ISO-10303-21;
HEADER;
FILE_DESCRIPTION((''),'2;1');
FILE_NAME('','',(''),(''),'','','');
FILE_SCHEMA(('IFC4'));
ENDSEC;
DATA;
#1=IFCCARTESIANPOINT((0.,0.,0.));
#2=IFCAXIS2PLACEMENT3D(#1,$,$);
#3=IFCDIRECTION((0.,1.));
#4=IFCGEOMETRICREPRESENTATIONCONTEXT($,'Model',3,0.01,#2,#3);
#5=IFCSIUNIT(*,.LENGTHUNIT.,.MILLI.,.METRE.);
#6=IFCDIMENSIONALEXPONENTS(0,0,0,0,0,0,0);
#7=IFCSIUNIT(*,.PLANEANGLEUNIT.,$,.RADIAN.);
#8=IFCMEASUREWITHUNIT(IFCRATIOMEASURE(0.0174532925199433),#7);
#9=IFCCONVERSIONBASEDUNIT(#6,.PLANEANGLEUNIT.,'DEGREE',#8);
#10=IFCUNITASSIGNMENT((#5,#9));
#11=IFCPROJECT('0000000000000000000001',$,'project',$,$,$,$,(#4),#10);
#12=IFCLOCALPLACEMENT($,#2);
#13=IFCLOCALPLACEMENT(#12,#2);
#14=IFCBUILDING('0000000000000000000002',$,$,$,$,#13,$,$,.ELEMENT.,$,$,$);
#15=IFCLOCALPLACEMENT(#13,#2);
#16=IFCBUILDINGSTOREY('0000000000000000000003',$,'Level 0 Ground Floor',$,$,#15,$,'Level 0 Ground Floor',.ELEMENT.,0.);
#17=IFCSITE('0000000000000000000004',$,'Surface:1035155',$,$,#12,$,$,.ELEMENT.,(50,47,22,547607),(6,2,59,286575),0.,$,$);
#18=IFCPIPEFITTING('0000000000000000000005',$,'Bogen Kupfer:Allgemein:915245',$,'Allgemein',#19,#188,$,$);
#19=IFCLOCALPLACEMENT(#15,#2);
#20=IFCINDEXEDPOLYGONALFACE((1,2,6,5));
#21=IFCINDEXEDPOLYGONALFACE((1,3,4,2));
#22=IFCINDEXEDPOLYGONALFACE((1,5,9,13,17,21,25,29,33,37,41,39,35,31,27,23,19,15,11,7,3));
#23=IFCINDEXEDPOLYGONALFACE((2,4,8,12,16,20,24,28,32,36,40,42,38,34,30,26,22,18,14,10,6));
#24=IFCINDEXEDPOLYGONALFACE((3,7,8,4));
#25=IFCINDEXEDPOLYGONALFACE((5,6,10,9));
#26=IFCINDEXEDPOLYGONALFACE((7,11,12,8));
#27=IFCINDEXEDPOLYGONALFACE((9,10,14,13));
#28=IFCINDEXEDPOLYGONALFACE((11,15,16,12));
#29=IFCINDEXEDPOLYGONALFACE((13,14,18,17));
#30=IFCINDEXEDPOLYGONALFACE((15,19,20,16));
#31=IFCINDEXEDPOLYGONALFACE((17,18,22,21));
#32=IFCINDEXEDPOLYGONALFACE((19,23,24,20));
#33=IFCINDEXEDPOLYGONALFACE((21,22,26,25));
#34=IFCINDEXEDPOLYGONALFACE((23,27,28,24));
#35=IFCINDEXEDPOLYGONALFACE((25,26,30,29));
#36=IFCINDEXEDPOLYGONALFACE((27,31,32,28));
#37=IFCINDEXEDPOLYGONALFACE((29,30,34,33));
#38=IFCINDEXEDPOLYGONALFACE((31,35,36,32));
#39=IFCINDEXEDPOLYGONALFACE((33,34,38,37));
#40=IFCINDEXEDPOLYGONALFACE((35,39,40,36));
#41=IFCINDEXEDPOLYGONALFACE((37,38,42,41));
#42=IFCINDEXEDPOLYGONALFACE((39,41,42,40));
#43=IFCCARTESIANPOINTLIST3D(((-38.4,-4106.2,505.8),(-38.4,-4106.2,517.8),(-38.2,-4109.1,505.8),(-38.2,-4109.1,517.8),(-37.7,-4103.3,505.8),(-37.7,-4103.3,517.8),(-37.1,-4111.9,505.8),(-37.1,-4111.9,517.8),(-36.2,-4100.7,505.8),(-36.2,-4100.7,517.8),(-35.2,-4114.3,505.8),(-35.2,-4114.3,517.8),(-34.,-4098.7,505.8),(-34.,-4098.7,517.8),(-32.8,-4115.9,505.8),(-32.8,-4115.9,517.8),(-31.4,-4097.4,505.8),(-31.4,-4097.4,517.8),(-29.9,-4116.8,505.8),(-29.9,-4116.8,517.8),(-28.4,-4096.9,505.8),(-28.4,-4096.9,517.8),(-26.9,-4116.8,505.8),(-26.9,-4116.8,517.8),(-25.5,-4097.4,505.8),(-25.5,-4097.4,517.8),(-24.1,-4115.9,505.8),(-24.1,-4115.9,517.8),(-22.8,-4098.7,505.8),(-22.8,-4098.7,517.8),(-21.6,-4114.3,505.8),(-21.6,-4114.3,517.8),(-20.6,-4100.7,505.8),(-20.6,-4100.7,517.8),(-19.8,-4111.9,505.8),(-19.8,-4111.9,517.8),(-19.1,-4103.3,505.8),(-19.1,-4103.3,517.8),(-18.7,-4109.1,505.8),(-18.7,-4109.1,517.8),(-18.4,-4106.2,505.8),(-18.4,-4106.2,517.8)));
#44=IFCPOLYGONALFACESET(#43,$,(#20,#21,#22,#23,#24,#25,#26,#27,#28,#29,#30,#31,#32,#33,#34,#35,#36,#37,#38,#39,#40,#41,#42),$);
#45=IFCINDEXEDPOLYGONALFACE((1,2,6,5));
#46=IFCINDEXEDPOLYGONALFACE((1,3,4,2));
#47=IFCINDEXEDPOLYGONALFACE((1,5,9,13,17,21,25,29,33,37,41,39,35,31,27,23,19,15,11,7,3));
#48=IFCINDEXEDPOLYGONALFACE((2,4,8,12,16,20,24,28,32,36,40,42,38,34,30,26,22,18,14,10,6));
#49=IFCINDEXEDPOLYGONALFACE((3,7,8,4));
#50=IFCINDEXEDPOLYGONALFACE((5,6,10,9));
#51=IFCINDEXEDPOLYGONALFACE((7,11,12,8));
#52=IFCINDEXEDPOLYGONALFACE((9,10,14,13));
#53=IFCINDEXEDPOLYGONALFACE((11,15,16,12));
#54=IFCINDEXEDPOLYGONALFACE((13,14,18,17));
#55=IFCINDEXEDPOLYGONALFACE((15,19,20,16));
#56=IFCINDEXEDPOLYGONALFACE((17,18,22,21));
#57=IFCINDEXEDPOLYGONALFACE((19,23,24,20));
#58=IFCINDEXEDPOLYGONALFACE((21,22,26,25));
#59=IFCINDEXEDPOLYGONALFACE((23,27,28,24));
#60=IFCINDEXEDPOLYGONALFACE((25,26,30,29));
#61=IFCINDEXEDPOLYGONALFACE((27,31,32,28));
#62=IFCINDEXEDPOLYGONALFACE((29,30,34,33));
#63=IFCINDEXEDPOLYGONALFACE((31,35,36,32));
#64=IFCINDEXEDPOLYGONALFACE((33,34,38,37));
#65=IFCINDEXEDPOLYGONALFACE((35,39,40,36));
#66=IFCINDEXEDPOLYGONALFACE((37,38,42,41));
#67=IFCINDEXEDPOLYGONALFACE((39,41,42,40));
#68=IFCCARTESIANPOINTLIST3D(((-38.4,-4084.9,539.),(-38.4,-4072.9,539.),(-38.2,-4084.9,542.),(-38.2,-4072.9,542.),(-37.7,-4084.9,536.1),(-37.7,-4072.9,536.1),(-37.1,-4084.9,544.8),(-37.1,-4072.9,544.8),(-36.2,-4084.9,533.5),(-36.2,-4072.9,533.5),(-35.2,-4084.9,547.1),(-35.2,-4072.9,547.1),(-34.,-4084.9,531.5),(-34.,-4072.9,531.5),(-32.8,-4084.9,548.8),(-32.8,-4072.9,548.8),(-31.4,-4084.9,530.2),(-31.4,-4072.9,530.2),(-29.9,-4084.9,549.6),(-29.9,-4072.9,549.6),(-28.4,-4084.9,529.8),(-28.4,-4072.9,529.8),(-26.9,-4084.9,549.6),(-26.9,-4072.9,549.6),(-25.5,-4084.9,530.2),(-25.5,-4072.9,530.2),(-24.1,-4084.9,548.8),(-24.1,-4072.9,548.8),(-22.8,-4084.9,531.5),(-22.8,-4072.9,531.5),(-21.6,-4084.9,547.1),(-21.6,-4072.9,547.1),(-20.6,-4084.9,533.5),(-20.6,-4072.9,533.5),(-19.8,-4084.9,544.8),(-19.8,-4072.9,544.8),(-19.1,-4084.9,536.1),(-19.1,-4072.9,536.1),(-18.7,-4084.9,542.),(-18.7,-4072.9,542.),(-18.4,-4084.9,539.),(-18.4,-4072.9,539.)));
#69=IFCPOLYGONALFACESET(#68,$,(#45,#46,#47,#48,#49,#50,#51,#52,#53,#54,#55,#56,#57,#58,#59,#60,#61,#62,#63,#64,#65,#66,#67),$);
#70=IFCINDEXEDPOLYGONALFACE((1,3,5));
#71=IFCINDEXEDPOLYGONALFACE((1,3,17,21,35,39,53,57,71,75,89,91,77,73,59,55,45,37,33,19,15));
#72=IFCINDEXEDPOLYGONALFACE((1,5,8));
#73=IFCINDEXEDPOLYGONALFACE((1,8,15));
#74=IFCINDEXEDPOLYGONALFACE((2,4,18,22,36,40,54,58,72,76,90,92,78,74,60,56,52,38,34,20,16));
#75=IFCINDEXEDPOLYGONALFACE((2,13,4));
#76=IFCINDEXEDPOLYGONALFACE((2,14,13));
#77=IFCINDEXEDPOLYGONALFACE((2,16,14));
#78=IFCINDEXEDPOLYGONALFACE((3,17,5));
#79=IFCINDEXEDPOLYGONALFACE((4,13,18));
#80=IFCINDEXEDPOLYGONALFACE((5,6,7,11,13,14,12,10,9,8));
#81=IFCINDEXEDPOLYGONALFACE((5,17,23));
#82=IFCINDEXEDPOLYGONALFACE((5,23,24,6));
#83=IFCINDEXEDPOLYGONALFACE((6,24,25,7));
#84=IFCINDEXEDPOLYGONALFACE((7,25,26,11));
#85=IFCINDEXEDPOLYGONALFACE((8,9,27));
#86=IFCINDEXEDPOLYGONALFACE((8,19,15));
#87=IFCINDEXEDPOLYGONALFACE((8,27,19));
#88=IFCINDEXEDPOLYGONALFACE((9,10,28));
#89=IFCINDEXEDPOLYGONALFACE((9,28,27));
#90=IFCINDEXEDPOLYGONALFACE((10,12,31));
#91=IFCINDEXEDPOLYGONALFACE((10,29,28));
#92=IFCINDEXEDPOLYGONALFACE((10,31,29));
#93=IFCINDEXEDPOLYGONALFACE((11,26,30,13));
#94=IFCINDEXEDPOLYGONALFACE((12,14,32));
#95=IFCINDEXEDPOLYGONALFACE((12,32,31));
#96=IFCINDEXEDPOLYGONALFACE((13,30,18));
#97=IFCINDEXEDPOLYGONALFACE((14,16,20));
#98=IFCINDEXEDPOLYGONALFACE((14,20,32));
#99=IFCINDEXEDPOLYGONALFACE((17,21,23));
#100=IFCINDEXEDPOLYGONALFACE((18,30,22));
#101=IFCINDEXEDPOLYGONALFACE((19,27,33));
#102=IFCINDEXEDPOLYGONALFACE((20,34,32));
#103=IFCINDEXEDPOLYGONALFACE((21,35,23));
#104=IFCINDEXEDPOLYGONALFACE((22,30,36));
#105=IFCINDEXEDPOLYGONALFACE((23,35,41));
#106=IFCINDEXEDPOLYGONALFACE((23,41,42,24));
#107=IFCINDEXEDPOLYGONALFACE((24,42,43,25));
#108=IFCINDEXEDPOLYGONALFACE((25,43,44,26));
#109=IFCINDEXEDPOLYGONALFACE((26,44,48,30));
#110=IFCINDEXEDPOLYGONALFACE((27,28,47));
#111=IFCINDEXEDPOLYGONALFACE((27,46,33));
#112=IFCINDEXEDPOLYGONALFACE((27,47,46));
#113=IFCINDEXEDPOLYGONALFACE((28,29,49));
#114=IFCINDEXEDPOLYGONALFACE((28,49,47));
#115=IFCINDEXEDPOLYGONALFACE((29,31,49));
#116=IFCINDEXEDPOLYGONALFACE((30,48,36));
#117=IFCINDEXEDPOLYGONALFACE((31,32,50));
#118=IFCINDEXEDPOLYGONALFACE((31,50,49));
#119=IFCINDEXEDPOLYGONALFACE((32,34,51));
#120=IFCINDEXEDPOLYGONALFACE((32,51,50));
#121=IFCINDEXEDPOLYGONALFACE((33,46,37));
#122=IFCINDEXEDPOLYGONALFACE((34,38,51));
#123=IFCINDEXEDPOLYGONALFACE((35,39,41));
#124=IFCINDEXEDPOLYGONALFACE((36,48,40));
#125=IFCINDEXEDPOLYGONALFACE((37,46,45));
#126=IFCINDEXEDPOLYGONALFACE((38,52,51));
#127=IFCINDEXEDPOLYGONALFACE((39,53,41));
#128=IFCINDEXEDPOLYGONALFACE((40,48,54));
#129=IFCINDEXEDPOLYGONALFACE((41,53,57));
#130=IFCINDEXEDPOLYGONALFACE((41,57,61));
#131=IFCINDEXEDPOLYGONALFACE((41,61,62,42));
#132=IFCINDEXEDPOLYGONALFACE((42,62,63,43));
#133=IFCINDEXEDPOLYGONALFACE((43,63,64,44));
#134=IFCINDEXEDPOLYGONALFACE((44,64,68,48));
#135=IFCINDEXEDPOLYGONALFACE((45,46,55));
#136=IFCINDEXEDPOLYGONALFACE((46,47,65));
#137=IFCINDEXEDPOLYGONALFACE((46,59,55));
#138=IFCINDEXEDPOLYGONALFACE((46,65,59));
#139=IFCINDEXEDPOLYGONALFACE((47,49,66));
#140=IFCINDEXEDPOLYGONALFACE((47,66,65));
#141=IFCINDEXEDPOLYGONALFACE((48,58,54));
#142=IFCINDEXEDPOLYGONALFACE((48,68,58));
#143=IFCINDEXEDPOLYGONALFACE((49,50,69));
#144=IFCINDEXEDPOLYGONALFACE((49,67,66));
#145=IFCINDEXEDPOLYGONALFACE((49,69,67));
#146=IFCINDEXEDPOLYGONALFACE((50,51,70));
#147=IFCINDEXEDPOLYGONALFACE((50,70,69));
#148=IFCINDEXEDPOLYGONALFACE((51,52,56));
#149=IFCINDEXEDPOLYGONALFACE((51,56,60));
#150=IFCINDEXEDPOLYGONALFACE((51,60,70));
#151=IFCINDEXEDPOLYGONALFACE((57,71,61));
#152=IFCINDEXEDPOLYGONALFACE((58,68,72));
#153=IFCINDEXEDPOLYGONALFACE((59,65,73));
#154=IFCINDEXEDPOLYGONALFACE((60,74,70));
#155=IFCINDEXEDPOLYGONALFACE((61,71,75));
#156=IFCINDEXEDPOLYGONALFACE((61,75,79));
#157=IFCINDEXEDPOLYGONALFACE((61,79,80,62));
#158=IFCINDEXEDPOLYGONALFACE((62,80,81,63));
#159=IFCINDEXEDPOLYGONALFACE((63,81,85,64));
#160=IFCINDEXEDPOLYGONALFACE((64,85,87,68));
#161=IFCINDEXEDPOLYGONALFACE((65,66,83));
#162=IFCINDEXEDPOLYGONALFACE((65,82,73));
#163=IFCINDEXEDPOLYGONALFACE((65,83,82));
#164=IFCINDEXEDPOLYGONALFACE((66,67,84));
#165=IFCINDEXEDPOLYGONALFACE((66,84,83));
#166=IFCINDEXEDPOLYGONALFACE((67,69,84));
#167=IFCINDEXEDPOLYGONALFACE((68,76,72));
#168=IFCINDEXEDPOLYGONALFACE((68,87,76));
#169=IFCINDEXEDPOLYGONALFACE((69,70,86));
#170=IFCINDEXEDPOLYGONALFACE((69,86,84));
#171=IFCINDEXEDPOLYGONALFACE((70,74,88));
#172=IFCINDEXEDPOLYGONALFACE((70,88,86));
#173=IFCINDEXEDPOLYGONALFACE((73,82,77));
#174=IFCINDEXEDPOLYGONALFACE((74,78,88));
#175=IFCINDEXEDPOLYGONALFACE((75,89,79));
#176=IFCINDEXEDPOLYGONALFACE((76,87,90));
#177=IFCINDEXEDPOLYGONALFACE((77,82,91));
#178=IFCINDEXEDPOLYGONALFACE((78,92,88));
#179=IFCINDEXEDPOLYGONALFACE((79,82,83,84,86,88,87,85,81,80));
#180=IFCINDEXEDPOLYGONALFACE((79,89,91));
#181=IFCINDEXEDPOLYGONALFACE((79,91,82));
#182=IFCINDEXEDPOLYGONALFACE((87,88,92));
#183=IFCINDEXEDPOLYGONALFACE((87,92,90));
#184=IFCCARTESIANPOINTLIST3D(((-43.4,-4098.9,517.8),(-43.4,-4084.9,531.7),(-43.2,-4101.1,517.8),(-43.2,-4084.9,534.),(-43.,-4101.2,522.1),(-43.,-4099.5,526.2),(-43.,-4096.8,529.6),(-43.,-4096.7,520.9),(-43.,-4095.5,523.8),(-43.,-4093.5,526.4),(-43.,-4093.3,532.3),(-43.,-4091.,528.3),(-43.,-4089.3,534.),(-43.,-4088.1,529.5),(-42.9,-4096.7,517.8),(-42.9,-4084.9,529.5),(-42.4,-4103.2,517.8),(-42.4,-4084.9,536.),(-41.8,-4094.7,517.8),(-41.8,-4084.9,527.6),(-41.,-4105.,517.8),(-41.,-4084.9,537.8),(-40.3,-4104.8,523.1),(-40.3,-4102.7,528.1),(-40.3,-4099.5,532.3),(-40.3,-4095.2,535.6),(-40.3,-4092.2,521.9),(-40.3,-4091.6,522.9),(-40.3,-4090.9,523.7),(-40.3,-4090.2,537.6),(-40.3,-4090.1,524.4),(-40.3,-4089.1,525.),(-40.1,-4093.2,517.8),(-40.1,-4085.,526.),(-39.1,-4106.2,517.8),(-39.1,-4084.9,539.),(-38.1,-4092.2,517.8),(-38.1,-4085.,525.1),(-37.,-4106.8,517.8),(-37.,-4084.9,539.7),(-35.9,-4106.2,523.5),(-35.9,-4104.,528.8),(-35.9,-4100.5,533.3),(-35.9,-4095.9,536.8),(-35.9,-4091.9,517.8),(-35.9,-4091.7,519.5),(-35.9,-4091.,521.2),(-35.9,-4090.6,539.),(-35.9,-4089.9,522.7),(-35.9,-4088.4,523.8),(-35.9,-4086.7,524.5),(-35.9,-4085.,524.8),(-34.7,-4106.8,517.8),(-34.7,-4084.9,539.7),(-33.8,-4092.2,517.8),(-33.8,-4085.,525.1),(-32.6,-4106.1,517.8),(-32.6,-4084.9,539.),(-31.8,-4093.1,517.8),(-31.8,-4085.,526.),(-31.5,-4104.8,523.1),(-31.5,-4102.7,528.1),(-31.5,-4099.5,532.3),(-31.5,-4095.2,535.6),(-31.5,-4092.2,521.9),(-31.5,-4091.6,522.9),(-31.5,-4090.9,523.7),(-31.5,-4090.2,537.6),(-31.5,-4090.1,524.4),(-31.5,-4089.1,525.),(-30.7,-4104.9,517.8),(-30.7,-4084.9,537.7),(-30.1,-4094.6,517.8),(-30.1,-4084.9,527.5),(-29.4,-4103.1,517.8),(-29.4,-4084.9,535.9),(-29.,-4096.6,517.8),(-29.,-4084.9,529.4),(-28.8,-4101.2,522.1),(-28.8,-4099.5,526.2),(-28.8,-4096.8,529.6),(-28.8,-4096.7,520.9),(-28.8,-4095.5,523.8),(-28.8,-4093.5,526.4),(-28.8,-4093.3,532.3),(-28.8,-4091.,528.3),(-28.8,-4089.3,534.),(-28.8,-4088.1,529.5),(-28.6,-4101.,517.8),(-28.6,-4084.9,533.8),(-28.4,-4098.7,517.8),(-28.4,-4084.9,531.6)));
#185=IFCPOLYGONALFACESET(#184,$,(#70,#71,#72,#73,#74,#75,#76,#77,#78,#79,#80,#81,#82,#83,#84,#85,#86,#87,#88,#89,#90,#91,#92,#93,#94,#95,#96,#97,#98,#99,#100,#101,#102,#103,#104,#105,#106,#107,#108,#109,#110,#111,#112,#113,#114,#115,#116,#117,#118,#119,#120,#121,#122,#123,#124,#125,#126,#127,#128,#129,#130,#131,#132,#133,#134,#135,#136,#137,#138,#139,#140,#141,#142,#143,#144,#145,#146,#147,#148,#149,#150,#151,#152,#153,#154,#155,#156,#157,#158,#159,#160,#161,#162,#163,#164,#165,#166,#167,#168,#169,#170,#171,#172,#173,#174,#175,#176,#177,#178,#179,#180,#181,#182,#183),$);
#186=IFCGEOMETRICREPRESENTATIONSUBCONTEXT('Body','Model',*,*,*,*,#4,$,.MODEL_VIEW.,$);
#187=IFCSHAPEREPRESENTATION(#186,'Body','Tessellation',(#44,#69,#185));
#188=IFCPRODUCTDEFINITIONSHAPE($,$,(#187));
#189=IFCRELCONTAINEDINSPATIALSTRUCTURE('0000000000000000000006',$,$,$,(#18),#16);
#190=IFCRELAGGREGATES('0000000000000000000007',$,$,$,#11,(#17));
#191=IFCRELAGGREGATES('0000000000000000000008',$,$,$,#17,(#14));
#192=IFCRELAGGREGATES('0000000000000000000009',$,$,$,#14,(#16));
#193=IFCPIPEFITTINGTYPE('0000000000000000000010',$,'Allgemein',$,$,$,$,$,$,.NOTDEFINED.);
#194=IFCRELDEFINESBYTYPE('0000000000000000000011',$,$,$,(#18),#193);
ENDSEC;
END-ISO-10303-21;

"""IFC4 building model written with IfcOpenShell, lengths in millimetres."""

from ifc_helpers import new_model, entity, si_unit, converted_unit, direction, frame, frame_2d, origin, place, context, subcontext, project, spatial, circle, extrude, source, transform, mapped, type_object, type_shapes, element, save


model = new_model("IFC4")

# Units and contexts
model_context = context("Model", 3, precision=0.01, world=origin(), true_north=direction((0.0, 1.0)))
body_context = subcontext(model_context, "Body", "Model", "MODEL_VIEW")
ifc_project = project(units=[si_unit("LENGTHUNIT", "METRE", prefix="MILLI"), converted_unit("PLANEANGLEUNIT", "DEGREE", entity("IfcRatioMeasure", 0.0174532925199433), si_unit("PLANEANGLEUNIT", "RADIAN"), dimensions=[0, 0, 0, 0, 0, 0, 0])], contexts=[model_context])

# Site, building, storey
site_placement = place(None, origin())
site = spatial("IfcSite", under=ifc_project, at=site_placement, Name="Surface:1035155", CompositionType="ELEMENT", RefLatitude=(50, 47, 22, 547607), RefLongitude=(6, 2, 59, 286575), RefElevation=0.0)
building_placement = place(site_placement, origin())
building = spatial("IfcBuilding", under=site, at=building_placement, CompositionType="ELEMENT")
storey_placement = place(building_placement, origin())
storey = spatial("IfcBuildingStorey", under=building, at=storey_placement, Name="Level 0 Ground Floor", LongName="Level 0 Ground Floor", CompositionType="ELEMENT", Elevation=0.0)

# Shared definitions
pipe_fitting_type = type_object("IfcPipeFittingType", Name="Allgemein", PredefinedType="NOTDEFINED")
ifc_direction = entity("IfcDirection", [0.0, 0.0, -1.0])
trimmed_curve = entity("IfcTrimmedCurve", entity("IfcCircle", entity("IfcAxis2Placement2D", entity("IfcCartesianPoint", [-14.5, 0.0]), entity("IfcDirection", [0.0, 1.0])), 14.5), [entity("IfcParameterValue", 270.0)], [entity("IfcParameterValue", 0.0)], True, "PARAMETER")
shared_shape_1 = source(origin(), body_context, "Body", "SolidModel", [
    extrude(circle(Radius=10.0, at=frame_2d((0.0, 0.0), x_axis=(1.0, 0.0))), frame((0.0, 22.0, 0.0), z_axis=(0.0, 1.0, 0.0), x_axis=(-1.0, 0.0, 0.0)), (0.0, 0.0, 1.0), 12.0),
    extrude(circle(Radius=10.0, at=frame_2d((0.0, 0.0), x_axis=(1.0, 0.0))), frame((-34.0, 0.0, 0.0), z_axis=(1.0, 0.0, 0.0), x_axis=(0.0, 1.0, 0.0)), (0.0, 0.0, 1.0), 12.0),
    entity("IfcSurfaceCurveSweptAreaSolid", entity("IfcCircleProfileDef", "AREA", None, entity("IfcAxis2Placement2D", entity("IfcCartesianPoint", [0.0, 7.5]), entity("IfcDirection", [1.0, 0.0])), 7.5), entity("IfcAxis2Placement3D", entity("IfcCartesianPoint", [-7.5, 22.0, 0.0]), ifc_direction, entity("IfcDirection", [1.0, 0.0, 0.0])), trimmed_curve, 0.0, 90.0, entity("IfcSurfaceOfLinearExtrusion", entity("IfcArbitraryOpenProfileDef", "CURVE", None, trimmed_curve), entity("IfcAxis2Placement3D", entity("IfcCartesianPoint", [0.0, 0.0, -304.8])), ifc_direction, 1.0)),
])
type_shapes(pipe_fitting_type, [shared_shape_1])

# Pipe fitting
for number, where, z_axis, x_axis, name in (
    (1, (-28.4, -4106.9, 539.8), (1.0, 0.0, 0.0), (0.0, -1.0, 0.0), "Bogen Kupfer:Allgemein:915245"),
):
    element("IfcPipeFitting", number, at=place(storey_placement, frame(where, z_axis=z_axis, x_axis=x_axis)), inside=storey, type_object=pipe_fitting_type, Name=name, ObjectType="Allgemein", context=body_context, shape_type="MappedRepresentation", body=[
        mapped(shared_shape_1, transform((0.0, 0.0, 0.0), scale=1.0)),
    ])

save(model, "model.ifc")
